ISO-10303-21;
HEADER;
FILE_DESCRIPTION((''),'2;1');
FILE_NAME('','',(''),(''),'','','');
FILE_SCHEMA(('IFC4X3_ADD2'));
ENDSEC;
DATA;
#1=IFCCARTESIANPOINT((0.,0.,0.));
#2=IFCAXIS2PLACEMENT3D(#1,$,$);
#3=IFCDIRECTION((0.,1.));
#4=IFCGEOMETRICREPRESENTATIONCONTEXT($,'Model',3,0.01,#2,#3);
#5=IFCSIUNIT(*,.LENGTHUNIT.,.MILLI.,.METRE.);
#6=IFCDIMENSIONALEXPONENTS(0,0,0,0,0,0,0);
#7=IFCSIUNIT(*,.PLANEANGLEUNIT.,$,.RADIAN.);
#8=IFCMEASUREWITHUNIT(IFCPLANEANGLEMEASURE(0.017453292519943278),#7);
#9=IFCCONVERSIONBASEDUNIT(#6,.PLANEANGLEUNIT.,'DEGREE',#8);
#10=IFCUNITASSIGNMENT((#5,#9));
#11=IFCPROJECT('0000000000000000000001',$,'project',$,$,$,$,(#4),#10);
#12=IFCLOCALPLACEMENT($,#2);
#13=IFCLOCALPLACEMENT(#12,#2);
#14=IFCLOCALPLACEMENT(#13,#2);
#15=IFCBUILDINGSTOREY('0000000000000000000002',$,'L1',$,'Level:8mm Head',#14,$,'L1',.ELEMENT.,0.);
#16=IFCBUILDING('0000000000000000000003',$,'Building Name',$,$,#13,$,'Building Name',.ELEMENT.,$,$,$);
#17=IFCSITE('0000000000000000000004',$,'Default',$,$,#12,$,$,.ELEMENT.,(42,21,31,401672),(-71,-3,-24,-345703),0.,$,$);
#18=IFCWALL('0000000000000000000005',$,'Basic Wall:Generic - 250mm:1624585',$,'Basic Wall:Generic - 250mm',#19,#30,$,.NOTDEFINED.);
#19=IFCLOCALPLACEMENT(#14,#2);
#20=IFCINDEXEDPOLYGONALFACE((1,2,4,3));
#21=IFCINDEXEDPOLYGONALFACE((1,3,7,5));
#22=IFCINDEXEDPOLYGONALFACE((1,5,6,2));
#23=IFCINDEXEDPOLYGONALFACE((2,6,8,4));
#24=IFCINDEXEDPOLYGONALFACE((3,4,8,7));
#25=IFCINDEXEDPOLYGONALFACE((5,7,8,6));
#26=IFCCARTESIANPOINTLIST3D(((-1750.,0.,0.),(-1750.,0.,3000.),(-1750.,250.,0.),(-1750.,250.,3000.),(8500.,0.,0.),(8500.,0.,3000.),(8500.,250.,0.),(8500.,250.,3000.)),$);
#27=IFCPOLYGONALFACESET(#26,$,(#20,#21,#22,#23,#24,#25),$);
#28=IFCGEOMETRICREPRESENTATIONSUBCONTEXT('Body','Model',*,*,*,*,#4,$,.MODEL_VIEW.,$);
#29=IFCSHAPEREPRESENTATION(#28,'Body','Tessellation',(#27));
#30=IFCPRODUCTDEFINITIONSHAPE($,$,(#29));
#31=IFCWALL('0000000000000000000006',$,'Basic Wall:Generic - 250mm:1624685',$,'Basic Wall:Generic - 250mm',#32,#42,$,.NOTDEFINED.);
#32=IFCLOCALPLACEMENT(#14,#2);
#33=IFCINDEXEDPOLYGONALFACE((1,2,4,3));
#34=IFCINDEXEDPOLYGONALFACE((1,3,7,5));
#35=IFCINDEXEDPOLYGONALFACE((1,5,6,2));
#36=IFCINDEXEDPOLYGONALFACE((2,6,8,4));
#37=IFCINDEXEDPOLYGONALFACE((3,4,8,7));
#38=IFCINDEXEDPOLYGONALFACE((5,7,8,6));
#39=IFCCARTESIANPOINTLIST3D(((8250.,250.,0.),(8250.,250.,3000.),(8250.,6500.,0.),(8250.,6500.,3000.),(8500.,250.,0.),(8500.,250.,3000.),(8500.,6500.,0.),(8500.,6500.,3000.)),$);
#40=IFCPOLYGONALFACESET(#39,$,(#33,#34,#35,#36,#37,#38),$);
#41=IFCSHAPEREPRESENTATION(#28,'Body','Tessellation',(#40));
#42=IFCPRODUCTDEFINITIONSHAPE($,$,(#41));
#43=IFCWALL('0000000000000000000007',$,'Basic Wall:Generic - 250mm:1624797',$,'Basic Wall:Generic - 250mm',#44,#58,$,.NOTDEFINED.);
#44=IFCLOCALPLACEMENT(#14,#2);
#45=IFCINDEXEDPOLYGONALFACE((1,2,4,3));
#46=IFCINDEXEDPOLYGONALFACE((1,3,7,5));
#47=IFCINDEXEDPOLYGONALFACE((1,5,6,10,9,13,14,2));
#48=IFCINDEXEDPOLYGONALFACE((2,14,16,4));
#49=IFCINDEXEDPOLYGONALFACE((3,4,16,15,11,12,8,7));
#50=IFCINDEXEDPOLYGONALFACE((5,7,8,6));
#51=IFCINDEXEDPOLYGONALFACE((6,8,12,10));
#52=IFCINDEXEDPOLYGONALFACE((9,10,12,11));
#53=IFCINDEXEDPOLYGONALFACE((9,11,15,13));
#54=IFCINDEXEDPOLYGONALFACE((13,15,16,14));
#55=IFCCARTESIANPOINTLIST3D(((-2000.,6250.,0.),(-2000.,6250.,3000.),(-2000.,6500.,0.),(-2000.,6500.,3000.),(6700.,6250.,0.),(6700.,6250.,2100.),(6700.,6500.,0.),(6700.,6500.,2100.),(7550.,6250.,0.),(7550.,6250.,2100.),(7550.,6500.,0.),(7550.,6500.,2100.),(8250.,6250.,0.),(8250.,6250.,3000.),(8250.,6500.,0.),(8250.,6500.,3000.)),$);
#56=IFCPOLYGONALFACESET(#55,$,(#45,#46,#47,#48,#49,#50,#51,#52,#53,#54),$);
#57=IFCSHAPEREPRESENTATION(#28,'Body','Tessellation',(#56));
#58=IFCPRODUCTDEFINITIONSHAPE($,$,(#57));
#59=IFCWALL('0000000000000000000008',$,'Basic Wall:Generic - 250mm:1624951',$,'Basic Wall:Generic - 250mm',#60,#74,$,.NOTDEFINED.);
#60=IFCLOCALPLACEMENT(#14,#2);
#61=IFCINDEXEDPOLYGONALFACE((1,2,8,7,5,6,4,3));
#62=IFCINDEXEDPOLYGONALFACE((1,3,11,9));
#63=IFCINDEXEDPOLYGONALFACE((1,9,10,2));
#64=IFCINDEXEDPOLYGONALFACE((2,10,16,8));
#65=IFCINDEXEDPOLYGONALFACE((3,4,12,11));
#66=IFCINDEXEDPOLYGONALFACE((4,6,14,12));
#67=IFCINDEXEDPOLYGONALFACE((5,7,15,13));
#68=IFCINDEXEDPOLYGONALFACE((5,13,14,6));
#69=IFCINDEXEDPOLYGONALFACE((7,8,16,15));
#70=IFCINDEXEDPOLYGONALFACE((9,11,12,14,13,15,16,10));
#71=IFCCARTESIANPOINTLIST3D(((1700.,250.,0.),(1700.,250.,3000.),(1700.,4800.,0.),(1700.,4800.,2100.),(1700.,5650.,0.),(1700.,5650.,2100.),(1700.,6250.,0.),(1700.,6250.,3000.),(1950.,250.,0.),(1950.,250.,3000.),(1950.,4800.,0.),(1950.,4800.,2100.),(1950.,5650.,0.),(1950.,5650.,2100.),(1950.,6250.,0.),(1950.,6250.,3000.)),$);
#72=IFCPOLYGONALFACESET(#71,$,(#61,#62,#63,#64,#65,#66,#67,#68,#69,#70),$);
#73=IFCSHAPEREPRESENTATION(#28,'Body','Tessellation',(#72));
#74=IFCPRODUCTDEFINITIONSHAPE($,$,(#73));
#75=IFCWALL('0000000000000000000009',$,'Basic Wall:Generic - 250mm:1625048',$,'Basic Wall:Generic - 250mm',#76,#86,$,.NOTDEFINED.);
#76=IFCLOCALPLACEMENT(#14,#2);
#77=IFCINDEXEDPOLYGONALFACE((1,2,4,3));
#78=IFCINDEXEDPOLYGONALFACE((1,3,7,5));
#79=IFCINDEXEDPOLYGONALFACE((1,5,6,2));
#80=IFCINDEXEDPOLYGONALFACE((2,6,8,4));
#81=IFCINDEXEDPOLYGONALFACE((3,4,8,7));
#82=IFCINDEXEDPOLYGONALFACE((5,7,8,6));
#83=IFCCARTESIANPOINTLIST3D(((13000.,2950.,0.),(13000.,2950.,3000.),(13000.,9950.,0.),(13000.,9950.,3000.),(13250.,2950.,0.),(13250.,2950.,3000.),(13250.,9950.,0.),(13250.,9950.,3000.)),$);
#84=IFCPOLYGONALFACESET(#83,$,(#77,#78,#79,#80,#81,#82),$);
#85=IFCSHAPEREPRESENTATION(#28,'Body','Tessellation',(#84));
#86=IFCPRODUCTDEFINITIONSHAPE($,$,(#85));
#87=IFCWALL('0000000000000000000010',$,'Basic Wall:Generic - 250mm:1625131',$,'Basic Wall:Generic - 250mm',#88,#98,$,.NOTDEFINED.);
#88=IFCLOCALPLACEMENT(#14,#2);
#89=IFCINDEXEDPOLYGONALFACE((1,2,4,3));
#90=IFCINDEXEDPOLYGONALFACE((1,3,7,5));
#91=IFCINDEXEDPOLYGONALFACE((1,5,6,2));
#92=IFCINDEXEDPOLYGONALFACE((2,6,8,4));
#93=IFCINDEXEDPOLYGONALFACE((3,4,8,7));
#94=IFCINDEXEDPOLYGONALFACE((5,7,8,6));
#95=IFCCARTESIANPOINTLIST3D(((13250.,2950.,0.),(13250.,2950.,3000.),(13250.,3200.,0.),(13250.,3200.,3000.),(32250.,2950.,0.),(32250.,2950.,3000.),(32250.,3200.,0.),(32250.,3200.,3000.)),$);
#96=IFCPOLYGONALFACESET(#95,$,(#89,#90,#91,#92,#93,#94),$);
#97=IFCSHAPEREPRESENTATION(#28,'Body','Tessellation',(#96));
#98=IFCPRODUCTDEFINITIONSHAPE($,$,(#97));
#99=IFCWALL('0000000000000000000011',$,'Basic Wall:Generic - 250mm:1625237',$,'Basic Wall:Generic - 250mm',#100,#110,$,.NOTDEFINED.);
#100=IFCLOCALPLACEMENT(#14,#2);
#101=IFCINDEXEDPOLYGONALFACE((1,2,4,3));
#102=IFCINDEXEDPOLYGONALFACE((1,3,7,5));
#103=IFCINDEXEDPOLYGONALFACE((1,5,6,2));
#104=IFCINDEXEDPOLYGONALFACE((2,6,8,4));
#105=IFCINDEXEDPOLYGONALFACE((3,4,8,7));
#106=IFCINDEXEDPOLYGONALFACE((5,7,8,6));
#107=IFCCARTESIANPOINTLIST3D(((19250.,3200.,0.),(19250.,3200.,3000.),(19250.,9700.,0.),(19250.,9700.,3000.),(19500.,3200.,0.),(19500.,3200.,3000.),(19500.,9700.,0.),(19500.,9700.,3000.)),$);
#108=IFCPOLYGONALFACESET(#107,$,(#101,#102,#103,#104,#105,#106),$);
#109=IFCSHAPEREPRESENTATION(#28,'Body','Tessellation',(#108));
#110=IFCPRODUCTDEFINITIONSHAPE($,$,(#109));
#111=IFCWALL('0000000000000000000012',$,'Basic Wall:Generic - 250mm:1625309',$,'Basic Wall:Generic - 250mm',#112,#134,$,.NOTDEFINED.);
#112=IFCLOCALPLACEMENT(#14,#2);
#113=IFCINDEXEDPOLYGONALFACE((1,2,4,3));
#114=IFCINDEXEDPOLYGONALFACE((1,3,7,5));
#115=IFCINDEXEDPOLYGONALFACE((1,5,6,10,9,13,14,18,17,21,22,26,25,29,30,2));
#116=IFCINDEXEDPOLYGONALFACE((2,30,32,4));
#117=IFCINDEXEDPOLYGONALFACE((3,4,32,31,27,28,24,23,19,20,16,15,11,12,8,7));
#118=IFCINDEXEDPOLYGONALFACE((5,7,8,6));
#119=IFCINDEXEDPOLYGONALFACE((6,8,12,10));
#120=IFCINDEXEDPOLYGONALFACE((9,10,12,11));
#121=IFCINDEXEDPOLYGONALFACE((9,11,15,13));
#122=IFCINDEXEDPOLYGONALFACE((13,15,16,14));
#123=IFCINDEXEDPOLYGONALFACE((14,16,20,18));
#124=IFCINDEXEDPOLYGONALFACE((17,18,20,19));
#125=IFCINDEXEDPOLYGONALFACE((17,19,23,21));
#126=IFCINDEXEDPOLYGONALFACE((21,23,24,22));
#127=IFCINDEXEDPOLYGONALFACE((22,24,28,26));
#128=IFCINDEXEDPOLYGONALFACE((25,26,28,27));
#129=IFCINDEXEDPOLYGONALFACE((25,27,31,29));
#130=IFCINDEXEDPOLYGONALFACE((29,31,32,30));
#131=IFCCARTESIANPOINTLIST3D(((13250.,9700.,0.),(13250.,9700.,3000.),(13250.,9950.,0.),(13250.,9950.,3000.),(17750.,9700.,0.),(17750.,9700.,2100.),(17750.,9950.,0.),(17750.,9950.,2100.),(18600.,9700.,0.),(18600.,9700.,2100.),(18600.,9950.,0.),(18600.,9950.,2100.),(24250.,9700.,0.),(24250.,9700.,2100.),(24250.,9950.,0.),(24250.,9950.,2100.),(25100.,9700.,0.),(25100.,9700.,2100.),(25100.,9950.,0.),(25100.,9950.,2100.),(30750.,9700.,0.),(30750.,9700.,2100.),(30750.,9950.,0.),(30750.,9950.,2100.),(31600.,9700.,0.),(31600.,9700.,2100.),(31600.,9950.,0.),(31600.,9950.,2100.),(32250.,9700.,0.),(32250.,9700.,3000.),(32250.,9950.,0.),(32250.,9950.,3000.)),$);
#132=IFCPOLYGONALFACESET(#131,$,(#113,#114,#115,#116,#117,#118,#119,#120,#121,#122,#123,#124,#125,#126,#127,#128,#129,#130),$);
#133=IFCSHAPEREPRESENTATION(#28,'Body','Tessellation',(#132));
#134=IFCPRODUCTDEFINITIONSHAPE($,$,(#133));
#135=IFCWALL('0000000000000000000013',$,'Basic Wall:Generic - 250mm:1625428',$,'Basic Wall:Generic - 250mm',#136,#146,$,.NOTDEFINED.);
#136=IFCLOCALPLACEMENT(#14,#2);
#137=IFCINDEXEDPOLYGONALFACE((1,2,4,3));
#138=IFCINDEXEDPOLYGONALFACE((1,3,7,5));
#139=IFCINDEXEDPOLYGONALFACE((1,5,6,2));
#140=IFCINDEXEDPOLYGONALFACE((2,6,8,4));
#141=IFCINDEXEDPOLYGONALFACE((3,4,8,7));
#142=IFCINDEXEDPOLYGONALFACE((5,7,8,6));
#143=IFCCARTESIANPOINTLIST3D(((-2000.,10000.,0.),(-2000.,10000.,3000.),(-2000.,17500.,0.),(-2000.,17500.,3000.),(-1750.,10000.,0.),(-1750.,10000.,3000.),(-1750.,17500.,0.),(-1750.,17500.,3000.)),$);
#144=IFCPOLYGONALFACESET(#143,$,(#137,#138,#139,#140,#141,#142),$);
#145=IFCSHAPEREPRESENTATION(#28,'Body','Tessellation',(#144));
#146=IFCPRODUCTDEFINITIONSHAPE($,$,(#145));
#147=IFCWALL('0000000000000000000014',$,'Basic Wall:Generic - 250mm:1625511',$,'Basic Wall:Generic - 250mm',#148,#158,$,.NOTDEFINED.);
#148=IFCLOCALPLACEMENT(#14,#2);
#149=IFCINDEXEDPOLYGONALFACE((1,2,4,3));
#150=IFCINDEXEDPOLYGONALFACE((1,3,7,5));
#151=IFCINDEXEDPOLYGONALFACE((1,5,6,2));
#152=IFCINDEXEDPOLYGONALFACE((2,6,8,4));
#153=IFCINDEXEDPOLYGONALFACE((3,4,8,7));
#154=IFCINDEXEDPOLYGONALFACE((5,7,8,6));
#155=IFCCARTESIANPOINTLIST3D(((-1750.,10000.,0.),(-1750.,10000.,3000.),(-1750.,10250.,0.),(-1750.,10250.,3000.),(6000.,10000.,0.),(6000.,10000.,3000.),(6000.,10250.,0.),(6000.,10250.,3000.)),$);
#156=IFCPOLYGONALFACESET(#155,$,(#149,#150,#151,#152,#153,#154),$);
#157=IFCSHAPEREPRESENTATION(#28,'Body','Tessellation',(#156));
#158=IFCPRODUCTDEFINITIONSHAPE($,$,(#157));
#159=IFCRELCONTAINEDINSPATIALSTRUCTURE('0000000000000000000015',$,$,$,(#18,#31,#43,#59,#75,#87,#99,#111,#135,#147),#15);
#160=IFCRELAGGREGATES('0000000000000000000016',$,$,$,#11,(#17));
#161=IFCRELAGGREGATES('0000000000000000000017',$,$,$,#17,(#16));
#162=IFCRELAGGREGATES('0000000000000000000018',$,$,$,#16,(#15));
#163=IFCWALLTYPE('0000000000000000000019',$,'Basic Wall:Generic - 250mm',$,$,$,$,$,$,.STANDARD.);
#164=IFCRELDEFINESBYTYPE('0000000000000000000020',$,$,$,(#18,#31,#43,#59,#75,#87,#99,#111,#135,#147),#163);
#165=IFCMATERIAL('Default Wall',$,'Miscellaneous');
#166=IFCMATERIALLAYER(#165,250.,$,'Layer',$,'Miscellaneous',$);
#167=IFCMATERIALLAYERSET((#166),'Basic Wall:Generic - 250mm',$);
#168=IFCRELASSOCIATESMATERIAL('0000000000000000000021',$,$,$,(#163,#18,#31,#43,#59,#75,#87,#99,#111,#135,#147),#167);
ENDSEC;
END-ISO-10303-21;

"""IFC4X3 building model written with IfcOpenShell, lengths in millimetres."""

from ifc_helpers import new_model, entity, si_unit, converted_unit, direction, frame, frame_2d, origin, place, context, subcontext, project, spatial, rectangle, extrude, material, layer, layer_set, type_object, element, save


model = new_model("IFC4X3")

# Units and contexts
model_context = context("Model", 3, precision=0.01, world=origin(), true_north=direction((0.0, 1.0)))
body_context = subcontext(model_context, "Body", "Model", "MODEL_VIEW")
ifc_project = project(units=[si_unit("LENGTHUNIT", "METRE", prefix="MILLI"), converted_unit("PLANEANGLEUNIT", "DEGREE", entity("IfcPlaneAngleMeasure", 0.017453292519943278), si_unit("PLANEANGLEUNIT", "RADIAN"), dimensions=[0, 0, 0, 0, 0, 0, 0])], contexts=[model_context])

# Site, building, storey
site_placement = place(None, origin())
site = spatial("IfcSite", under=ifc_project, at=site_placement, Name="Default", CompositionType="ELEMENT", RefLatitude=(42, 21, 31, 401672), RefLongitude=(-71, -3, -24, -345703), RefElevation=0.0)
building_placement = place(site_placement, origin())
building = spatial("IfcBuilding", under=site, at=building_placement, Name="Building Name", LongName="Building Name", CompositionType="ELEMENT")
storey_placement = place(building_placement, origin())
storey = spatial("IfcBuildingStorey", under=building, at=storey_placement, Name="L1", ObjectType="Level:8mm Head", LongName="L1", CompositionType="ELEMENT", Elevation=0.0)

# Walls
ifc_material = material(Name="Default Wall", Category="Miscellaneous")
ifc_layer = layer(ifc_material, 250.0, Name="Layer", Category="Miscellaneous")
ifc_layer_set = layer_set([ifc_layer], Name="Basic Wall:Generic - 250mm")
wall_type = type_object("IfcWallType", Name="Basic Wall:Generic - 250mm", PredefinedType="STANDARD", material=ifc_layer_set)
wall_1_placement = place(storey_placement, frame((-1750.0, 125.0, 0.0)))
element("IfcWall", 1, at=wall_1_placement, inside=storey, type_object=wall_type, material=ifc_layer_set, Name="Basic Wall:Generic - 250mm:1624585", ObjectType="Basic Wall:Generic - 250mm", PredefinedType="NOTDEFINED", context=body_context, shape_type="SweptSolid", body=[
    extrude(rectangle(XDim=10250.0, YDim=250.0, at=frame_2d((5125.0, 0.0), x_axis=(-1.0, 0.0))), origin(), (0.0, 0.0, 1.0), 3000.0),
])
wall_2_placement = place(storey_placement, frame((8375.0, 250.0, 0.0), z_axis=(0.0, 0.0, 1.0), x_axis=(0.0, 1.0, 0.0)))
element("IfcWall", 2, at=wall_2_placement, inside=storey, type_object=wall_type, material=ifc_layer_set, Name="Basic Wall:Generic - 250mm:1624685", ObjectType="Basic Wall:Generic - 250mm", PredefinedType="NOTDEFINED", context=body_context, shape_type="SweptSolid", body=[
    extrude(rectangle(XDim=6250.0, YDim=250.0, at=frame_2d((3125.0, 0.0), x_axis=(-1.0, 0.0))), origin(), (0.0, 0.0, 1.0), 3000.0),
])

# Walls, openings
wall_3_placement = place(storey_placement, frame((8250.0, 6375.0, 0.0), z_axis=(0.0, 0.0, 1.0), x_axis=(-1.0, 0.0, 0.0)))
wall_3 = element("IfcWall", 3, at=wall_3_placement, inside=storey, type_object=wall_type, material=ifc_layer_set, Name="Basic Wall:Generic - 250mm:1624797", ObjectType="Basic Wall:Generic - 250mm", PredefinedType="NOTDEFINED", context=body_context, shape_type="SweptSolid", body=[
    extrude(rectangle(XDim=10250.0, YDim=250.0, at=frame_2d((5125.0, 0.0), x_axis=(1.0, 0.0))), origin(), (0.0, 0.0, 1.0), 3000.0),
])
opening_1_placement = place(wall_3_placement, frame((700.0, -125.0, 0.0)))
element("IfcOpeningElement", 4, at=opening_1_placement, cuts=wall_3, PredefinedType="OPENING", context=body_context, shape_type="SweptSolid", body=[
    extrude(rectangle(XDim=2100.0, YDim=850.0, at=frame_2d((1050.0, 425.0), x_axis=(1.0, 0.0))), frame((0.0, 0.0, 0.0), z_axis=(0.0, 1.0, 0.0), x_axis=(0.0, 0.0, 1.0)), (0.0, 0.0, 1.0), 250.0),
])
wall_4_placement = place(storey_placement, frame((1825.0, 6250.0, 0.0), z_axis=(0.0, 0.0, 1.0), x_axis=(0.0, -1.0, 0.0)))
wall_4 = element("IfcWall", 5, at=wall_4_placement, inside=storey, type_object=wall_type, material=ifc_layer_set, Name="Basic Wall:Generic - 250mm:1624951", ObjectType="Basic Wall:Generic - 250mm", PredefinedType="NOTDEFINED", context=body_context, shape_type="SweptSolid", body=[
    extrude(rectangle(XDim=6000.0, YDim=250.0, at=frame_2d((3000.0, 0.0), x_axis=(1.0, 0.0))), origin(), (0.0, 0.0, 1.0), 3000.0),
])
opening_2_placement = place(wall_4_placement, frame((1450.0, 125.0, 0.0)))
element("IfcOpeningElement", 6, at=opening_2_placement, cuts=wall_4, PredefinedType="OPENING", context=body_context, shape_type="SweptSolid", body=[
    extrude(rectangle(XDim=2100.0, YDim=850.0, at=frame_2d((1050.0, 425.0), x_axis=(1.0, 0.0))), frame((0.0, 0.0, 0.0), z_axis=(0.0, -1.0, 0.0), x_axis=(0.0, 0.0, 1.0)), (0.0, 0.0, 1.0), 250.0),
])

# Walls
wall_5_placement = place(storey_placement, frame((13125.0, 9950.0, 0.0), z_axis=(0.0, 0.0, 1.0), x_axis=(0.0, -1.0, 0.0)))
element("IfcWall", 7, at=wall_5_placement, inside=storey, type_object=wall_type, material=ifc_layer_set, Name="Basic Wall:Generic - 250mm:1625048", ObjectType="Basic Wall:Generic - 250mm", PredefinedType="NOTDEFINED", context=body_context, shape_type="SweptSolid", body=[
    extrude(rectangle(XDim=7000.0, YDim=250.0, at=frame_2d((3500.0, 0.0), x_axis=(-1.0, 0.0))), origin(), (0.0, 0.0, 1.0), 3000.0),
])
wall_6_placement = place(storey_placement, frame((13250.0, 3075.0, 0.0)))
element("IfcWall", 8, at=wall_6_placement, inside=storey, type_object=wall_type, material=ifc_layer_set, Name="Basic Wall:Generic - 250mm:1625131", ObjectType="Basic Wall:Generic - 250mm", PredefinedType="NOTDEFINED", context=body_context, shape_type="SweptSolid", body=[
    extrude(rectangle(XDim=19000.0, YDim=250.0, at=frame_2d((9500.0, 0.0), x_axis=(-1.0, 0.0))), origin(), (0.0, 0.0, 1.0), 3000.0),
])
wall_7_placement = place(storey_placement, frame((19375.0, 3200.0, 0.0), z_axis=(0.0, 0.0, 1.0), x_axis=(0.0, 1.0, 0.0)))
element("IfcWall", 9, at=wall_7_placement, inside=storey, type_object=wall_type, material=ifc_layer_set, Name="Basic Wall:Generic - 250mm:1625237", ObjectType="Basic Wall:Generic - 250mm", PredefinedType="NOTDEFINED", context=body_context, shape_type="SweptSolid", body=[
    extrude(rectangle(XDim=6500.0, YDim=250.0, at=frame_2d((3250.0, 0.0), x_axis=(-1.0, 0.0))), origin(), (0.0, 0.0, 1.0), 3000.0),
])

# Wall, openings
wall_8_placement = place(storey_placement, frame((32250.0, 9825.0, 0.0), z_axis=(0.0, 0.0, 1.0), x_axis=(-1.0, 0.0, 0.0)))
wall_8 = element("IfcWall", 10, at=wall_8_placement, inside=storey, type_object=wall_type, material=ifc_layer_set, Name="Basic Wall:Generic - 250mm:1625309", ObjectType="Basic Wall:Generic - 250mm", PredefinedType="NOTDEFINED", context=body_context, shape_type="SweptSolid", body=[
    extrude(rectangle(XDim=19000.0, YDim=250.0, at=frame_2d((9500.0, 0.0), x_axis=(1.0, 0.0))), origin(), (0.0, 0.0, 1.0), 3000.0),
])
opening_3_placement = place(wall_8_placement, frame((13650.0, -125.0, 0.0)))
element("IfcOpeningElement", 11, at=opening_3_placement, cuts=wall_8, PredefinedType="OPENING", context=body_context, shape_type="SweptSolid", body=[
    extrude(rectangle(XDim=2100.0, YDim=850.0, at=frame_2d((1050.0, 425.0), x_axis=(1.0, 0.0))), frame((0.0, 0.0, 0.0), z_axis=(0.0, 1.0, 0.0), x_axis=(0.0, 0.0, 1.0)), (0.0, 0.0, 1.0), 250.0),
])
opening_4_placement = place(wall_8_placement, frame((7150.0, -125.0, 0.0)))
element("IfcOpeningElement", 12, at=opening_4_placement, cuts=wall_8, PredefinedType="OPENING", context=body_context, shape_type="SweptSolid", body=[
    extrude(rectangle(XDim=2100.0, YDim=850.0, at=frame_2d((1050.0, 425.0), x_axis=(1.0, 0.0))), frame((0.0, 0.0, 0.0), z_axis=(0.0, 1.0, 0.0), x_axis=(0.0, 0.0, 1.0)), (0.0, 0.0, 1.0), 250.0),
])
opening_5_placement = place(wall_8_placement, frame((650.0, -125.0, 0.0)))
element("IfcOpeningElement", 13, at=opening_5_placement, cuts=wall_8, PredefinedType="OPENING", context=body_context, shape_type="SweptSolid", body=[
    extrude(rectangle(XDim=2100.0, YDim=850.0, at=frame_2d((1050.0, 425.0), x_axis=(1.0, 0.0))), frame((0.0, 0.0, 0.0), z_axis=(0.0, 1.0, 0.0), x_axis=(0.0, 0.0, 1.0)), (0.0, 0.0, 1.0), 250.0),
])

# Walls
wall_9_placement = place(storey_placement, frame((-1875.0, 17500.0, 0.0), z_axis=(0.0, 0.0, 1.0), x_axis=(0.0, -1.0, 0.0)))
element("IfcWall", 14, at=wall_9_placement, inside=storey, type_object=wall_type, material=ifc_layer_set, Name="Basic Wall:Generic - 250mm:1625428", ObjectType="Basic Wall:Generic - 250mm", PredefinedType="NOTDEFINED", context=body_context, shape_type="SweptSolid", body=[
    extrude(rectangle(XDim=7500.0, YDim=250.0, at=frame_2d((3750.0, 0.0), x_axis=(-1.0, 0.0))), origin(), (0.0, 0.0, 1.0), 3000.0),
])
wall_10_placement = place(storey_placement, frame((-1750.0, 10125.0, 0.0)))
element("IfcWall", 15, at=wall_10_placement, inside=storey, type_object=wall_type, material=ifc_layer_set, Name="Basic Wall:Generic - 250mm:1625511", ObjectType="Basic Wall:Generic - 250mm", PredefinedType="NOTDEFINED", context=body_context, shape_type="SweptSolid", body=[
    extrude(rectangle(XDim=7750.0, YDim=250.0, at=frame_2d((3875.0, 0.0), x_axis=(-1.0, 0.0))), origin(), (0.0, 0.0, 1.0), 3000.0),
])

save(model, "model.ifc")
